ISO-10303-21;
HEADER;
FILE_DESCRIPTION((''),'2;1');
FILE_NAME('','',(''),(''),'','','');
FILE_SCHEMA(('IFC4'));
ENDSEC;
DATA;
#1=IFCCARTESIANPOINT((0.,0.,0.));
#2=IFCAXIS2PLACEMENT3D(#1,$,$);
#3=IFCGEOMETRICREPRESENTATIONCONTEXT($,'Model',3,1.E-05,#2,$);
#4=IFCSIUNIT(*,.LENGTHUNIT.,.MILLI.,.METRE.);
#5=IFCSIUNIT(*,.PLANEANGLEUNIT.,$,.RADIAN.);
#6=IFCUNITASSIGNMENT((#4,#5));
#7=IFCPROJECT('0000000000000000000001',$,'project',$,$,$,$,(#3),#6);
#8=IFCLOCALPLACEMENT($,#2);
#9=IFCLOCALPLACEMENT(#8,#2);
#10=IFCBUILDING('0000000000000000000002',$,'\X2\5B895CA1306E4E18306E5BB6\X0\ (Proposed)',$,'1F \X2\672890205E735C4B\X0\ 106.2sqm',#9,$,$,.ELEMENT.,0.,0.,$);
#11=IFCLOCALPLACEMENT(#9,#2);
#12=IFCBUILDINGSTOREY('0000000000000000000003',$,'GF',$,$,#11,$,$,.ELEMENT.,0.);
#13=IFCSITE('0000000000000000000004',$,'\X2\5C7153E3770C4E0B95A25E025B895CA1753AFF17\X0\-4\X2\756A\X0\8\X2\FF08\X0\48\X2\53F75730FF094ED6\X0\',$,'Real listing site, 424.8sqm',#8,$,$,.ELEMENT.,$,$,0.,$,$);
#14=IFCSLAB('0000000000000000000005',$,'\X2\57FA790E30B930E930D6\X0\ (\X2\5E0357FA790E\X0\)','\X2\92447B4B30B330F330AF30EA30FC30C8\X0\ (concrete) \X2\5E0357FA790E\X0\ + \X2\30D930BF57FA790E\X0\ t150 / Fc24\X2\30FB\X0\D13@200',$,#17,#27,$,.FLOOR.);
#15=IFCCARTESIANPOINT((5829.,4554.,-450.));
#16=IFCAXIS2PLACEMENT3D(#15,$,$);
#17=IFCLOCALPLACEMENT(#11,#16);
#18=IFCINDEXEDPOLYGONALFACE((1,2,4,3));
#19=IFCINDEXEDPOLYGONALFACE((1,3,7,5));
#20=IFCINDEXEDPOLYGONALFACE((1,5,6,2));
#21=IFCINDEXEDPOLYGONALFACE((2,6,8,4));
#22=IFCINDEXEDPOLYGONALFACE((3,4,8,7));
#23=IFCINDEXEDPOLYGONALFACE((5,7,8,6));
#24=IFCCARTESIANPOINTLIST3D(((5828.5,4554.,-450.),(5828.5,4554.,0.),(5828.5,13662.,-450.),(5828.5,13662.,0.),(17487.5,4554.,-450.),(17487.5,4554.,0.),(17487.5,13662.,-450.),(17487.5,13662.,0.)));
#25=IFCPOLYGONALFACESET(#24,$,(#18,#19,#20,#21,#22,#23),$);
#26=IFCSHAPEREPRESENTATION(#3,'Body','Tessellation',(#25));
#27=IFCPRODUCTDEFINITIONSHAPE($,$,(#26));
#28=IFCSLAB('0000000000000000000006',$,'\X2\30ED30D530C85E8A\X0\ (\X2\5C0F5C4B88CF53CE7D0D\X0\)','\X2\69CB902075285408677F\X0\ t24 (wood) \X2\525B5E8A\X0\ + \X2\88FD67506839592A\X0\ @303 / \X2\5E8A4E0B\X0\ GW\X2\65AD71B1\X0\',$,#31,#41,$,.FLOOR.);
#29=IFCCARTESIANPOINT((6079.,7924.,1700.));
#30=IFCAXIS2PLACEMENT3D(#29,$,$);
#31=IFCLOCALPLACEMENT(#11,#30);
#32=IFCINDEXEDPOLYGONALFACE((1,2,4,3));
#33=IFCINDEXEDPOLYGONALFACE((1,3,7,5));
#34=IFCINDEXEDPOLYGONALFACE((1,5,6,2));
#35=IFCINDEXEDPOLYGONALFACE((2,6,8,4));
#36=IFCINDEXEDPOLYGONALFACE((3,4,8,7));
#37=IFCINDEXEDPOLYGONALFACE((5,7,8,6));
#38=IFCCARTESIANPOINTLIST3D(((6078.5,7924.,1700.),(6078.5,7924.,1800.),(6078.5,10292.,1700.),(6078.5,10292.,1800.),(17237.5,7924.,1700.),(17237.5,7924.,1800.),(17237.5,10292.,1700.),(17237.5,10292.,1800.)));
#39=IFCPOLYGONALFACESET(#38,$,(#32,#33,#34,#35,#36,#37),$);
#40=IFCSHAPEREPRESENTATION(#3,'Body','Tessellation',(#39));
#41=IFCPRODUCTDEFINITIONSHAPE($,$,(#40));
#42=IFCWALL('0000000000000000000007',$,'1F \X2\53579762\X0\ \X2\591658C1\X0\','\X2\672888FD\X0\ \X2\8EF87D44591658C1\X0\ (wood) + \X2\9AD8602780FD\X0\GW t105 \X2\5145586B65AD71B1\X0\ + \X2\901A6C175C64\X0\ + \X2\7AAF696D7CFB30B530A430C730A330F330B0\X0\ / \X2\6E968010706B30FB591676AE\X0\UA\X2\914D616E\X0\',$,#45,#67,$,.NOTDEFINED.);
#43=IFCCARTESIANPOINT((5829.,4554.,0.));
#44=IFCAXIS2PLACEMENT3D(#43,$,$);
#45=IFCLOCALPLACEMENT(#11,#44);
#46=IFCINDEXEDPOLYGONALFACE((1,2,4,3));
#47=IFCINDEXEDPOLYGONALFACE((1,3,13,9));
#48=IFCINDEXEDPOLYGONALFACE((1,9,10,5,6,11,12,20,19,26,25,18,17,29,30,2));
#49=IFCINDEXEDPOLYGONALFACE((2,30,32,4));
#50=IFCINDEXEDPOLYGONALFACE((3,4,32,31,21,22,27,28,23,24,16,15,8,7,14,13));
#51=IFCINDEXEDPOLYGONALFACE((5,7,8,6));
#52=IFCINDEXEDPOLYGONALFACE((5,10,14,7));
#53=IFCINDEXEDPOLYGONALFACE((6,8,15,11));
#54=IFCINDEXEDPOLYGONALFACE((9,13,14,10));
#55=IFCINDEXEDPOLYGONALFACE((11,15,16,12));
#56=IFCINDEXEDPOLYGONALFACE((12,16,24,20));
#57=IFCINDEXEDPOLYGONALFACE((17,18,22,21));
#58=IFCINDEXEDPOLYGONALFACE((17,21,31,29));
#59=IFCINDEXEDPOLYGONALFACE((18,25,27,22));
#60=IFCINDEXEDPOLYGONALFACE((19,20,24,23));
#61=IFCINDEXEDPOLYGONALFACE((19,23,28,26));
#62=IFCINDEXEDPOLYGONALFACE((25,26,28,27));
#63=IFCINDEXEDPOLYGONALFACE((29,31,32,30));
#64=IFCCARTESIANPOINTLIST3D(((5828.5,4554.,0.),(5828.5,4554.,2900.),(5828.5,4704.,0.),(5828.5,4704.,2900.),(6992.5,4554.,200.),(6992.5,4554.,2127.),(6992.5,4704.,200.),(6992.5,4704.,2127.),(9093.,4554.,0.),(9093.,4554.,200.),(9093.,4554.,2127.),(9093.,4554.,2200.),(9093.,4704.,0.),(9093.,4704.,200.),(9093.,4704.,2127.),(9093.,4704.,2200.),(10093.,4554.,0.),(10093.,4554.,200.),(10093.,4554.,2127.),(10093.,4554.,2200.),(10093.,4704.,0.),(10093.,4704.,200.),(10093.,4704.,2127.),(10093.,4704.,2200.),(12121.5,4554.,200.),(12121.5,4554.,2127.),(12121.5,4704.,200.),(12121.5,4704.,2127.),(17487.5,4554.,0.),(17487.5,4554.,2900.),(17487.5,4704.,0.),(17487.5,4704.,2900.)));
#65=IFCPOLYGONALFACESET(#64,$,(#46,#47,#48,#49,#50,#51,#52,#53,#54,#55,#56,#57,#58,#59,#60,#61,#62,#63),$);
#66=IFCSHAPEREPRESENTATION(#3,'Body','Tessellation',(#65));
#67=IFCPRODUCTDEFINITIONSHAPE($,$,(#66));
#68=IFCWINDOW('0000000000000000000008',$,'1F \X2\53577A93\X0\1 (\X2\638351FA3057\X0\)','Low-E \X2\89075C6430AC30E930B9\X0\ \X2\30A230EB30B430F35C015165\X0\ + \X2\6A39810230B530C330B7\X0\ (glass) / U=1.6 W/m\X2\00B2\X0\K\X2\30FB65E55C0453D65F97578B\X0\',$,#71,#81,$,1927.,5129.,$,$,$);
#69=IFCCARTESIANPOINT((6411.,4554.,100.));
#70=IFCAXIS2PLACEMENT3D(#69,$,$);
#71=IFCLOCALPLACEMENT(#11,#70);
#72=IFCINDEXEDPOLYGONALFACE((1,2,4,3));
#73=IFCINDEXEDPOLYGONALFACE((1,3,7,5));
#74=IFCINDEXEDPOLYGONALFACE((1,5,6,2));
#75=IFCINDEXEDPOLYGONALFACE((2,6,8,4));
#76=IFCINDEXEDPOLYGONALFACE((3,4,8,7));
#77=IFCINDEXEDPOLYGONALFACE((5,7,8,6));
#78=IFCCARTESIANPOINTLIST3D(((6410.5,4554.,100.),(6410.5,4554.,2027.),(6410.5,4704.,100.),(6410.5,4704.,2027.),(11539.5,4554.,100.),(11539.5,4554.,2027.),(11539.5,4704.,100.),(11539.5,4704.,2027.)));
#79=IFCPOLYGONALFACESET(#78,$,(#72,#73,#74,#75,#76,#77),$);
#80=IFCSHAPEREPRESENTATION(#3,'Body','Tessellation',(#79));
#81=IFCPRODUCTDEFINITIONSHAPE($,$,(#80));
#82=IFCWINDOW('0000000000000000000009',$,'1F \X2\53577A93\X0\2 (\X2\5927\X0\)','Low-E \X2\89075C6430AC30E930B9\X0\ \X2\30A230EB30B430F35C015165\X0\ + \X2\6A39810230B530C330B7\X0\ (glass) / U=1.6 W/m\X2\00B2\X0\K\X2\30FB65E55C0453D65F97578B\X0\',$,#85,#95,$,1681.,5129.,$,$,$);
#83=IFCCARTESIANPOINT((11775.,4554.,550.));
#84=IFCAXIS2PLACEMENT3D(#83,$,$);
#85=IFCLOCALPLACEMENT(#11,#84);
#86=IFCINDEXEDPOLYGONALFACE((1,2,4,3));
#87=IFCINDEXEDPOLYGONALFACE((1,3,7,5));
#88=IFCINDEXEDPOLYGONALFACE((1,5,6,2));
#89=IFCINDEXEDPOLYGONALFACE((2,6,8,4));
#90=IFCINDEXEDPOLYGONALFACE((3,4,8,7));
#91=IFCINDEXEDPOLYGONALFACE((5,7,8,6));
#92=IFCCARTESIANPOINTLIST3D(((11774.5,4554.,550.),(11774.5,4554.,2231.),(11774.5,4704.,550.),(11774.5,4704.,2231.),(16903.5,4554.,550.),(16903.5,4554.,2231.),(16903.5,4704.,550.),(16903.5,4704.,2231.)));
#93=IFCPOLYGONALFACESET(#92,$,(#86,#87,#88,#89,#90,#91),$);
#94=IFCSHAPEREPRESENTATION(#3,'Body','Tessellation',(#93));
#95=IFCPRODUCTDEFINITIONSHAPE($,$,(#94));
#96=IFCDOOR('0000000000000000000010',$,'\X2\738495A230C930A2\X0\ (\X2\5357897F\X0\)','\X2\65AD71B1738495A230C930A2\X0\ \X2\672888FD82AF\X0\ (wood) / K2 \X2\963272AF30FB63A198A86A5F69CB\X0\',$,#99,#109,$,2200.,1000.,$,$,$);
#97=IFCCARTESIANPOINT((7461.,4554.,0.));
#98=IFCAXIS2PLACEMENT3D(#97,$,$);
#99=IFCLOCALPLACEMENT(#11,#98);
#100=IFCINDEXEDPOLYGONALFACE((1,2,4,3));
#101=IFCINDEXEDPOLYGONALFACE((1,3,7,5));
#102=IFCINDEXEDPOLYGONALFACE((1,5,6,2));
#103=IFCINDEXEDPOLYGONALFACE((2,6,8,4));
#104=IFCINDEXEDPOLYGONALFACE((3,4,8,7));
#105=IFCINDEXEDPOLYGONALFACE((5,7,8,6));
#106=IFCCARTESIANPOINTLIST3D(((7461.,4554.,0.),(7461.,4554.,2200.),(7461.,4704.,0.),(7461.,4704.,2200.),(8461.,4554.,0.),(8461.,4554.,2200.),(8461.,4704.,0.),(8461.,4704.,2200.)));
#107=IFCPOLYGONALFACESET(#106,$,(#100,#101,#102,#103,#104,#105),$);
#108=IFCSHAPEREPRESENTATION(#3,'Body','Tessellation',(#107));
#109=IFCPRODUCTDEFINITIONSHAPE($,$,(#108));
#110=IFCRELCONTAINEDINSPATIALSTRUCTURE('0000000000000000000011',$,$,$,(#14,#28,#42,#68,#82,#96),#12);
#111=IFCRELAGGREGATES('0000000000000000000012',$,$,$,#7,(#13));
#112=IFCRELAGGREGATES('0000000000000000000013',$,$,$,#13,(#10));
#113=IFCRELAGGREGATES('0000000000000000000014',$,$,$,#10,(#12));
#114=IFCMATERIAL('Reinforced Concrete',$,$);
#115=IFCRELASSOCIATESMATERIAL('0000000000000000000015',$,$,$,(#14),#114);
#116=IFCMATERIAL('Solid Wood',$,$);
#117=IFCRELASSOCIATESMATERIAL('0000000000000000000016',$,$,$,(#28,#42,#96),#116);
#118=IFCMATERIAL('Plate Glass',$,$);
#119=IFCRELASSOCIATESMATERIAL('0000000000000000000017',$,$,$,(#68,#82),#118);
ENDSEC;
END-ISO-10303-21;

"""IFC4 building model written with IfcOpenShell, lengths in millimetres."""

from ifc_helpers import new_model, si_unit, frame, frame_2d, origin, place, context, project, spatial, rectangle, extrude, material, element, fill, save


model = new_model("IFC4")

# Units and contexts
model_context = context("Model", 3, precision=1e-05, world=origin())
ifc_project = project(units=[si_unit("LENGTHUNIT", "METRE", prefix="MILLI"), si_unit("PLANEANGLEUNIT", "RADIAN")], contexts=[model_context])

# Site, building, storey
site_placement = place(None, origin())
site = spatial("IfcSite", under=ifc_project, at=site_placement, Name="山口県下関市安岡町７-4番8（48号地）他", ObjectType="Real listing site, 424.8sqm", CompositionType="ELEMENT", RefElevation=0.0)
building_placement = place(site_placement, origin())
building = spatial("IfcBuilding", under=site, at=building_placement, Name="安岡の丘の家 (Proposed)", ObjectType="1F 木造平屋 106.2sqm", CompositionType="ELEMENT", ElevationOfRefHeight=0.0, ElevationOfTerrain=0.0)
storey_placement = place(building_placement, origin())
storey = spatial("IfcBuildingStorey", under=building, at=storey_placement, Name="GF", CompositionType="ELEMENT", Elevation=0.0)

# Slabs
ifc_material_1 = material(Name="Reinforced Concrete")
slab_1_placement = place(storey_placement, frame((5829.0, 4554.0, -450.0)))
element("IfcSlab", 1, at=slab_1_placement, inside=storey, material=ifc_material_1, Name="基礎スラブ (布基礎)", Description="鉄筋コンクリート (concrete) 布基礎 + ベタ基礎 t150 / Fc24・D13@200", PredefinedType="FLOOR", context=model_context, shape_type="SweptSolid", body=[
    extrude(rectangle(XDim=11659.0, YDim=9108.0, at=frame_2d((5829.0, 4554.0))), frame((5829.0, 4554.0, -450.0)), (0.0, 0.0, 1.0), 450.0),
])
ifc_material_2 = material(Name="Solid Wood")
slab_2_placement = place(storey_placement, frame((6079.0, 7924.0, 1700.0)))
element("IfcSlab", 2, at=slab_2_placement, inside=storey, material=ifc_material_2, Name="ロフト床 (小屋裏収納)", Description="構造用合板 t24 (wood) 剛床 + 製材根太 @303 / 床下 GW断熱", PredefinedType="FLOOR", context=model_context, shape_type="SweptSolid", body=[
    extrude(rectangle(XDim=11159.0, YDim=2368.0, at=frame_2d((5579.0, 1184.0))), frame((6079.0, 7924.0, 1700.0)), (0.0, 0.0, 1.0), 100.0),
])

# Wall, openings, windows, door
wall_1_placement = place(storey_placement, frame((5829.0, 4554.0, 0.0)))
wall_1 = element("IfcWall", 3, at=wall_1_placement, inside=storey, material=ifc_material_2, Name="1F 南面 外壁", Description="木製 軸組外壁 (wood) + 高性能GW t105 充填断熱 + 通気層 + 窯業系サイディング / 準耐火・外皮UA配慮", PredefinedType="NOTDEFINED", context=model_context, shape_type="SweptSolid", body=[
    extrude(rectangle(XDim=11659.0, YDim=150.0, at=frame_2d((5829.0, 75.0))), frame((5829.0, 4554.0, 0.0)), (0.0, 0.0, 1.0), 2900.0),
])
opening_1_placement = place(storey_placement, frame((6411.0, 4554.0, 100.0)))
opening_1 = element("IfcOpeningElement", 4, at=opening_1_placement, cuts=wall_1, PredefinedType="NOTDEFINED", context=model_context, shape_type="SweptSolid", body=[
    extrude(rectangle(XDim=5129.0, YDim=150.0, at=frame_2d((2564.0, 75.0))), frame((6411.0, 4554.0, 100.0)), (0.0, 0.0, 1.0), 1927.0),
])
opening_2_placement = place(storey_placement, frame((11775.0, 4554.0, 550.0)))
opening_2 = element("IfcOpeningElement", 5, at=opening_2_placement, cuts=wall_1, PredefinedType="NOTDEFINED", context=model_context, shape_type="SweptSolid", body=[
    extrude(rectangle(XDim=5129.0, YDim=150.0, at=frame_2d((2564.0, 75.0))), frame((11775.0, 4554.0, 550.0)), (0.0, 0.0, 1.0), 1681.0),
])
opening_3_placement = place(storey_placement, frame((7461.0, 4554.0, 0.0)))
opening_3 = element("IfcOpeningElement", 6, at=opening_3_placement, cuts=wall_1, PredefinedType="NOTDEFINED", context=model_context, shape_type="SweptSolid", body=[
    extrude(rectangle(XDim=1000.0, YDim=150.0, at=frame_2d((500.0, 75.0))), frame((7461.0, 4554.0, 0.0)), (0.0, 0.0, 1.0), 2200.0),
])
ifc_material_3 = material(Name="Plate Glass")
window_1_placement = place(storey_placement, frame((6411.0, 4554.0, 100.0)))
window_1 = element("IfcWindow", 7, at=window_1_placement, inside=storey, material=ifc_material_3, Name="1F 南窓1 (掃出し)", Description="Low-E 複層ガラス アルゴン封入 + 樹脂サッシ (glass) / U=1.6 W/m²K・日射取得型", OverallHeight=1927.0, OverallWidth=5129.0, context=model_context, shape_type="SweptSolid", body=[
    extrude(rectangle(XDim=5129.0, YDim=150.0, at=frame_2d((2564.0, 75.0))), frame((6411.0, 4554.0, 100.0)), (0.0, 0.0, 1.0), 1927.0),
])
fill(opening_1, window_1)
window_2_placement = place(storey_placement, frame((11775.0, 4554.0, 550.0)))
window_2 = element("IfcWindow", 8, at=window_2_placement, inside=storey, material=ifc_material_3, Name="1F 南窓2 (大)", Description="Low-E 複層ガラス アルゴン封入 + 樹脂サッシ (glass) / U=1.6 W/m²K・日射取得型", OverallHeight=1681.0, OverallWidth=5129.0, context=model_context, shape_type="SweptSolid", body=[
    extrude(rectangle(XDim=5129.0, YDim=150.0, at=frame_2d((2564.0, 75.0))), frame((11775.0, 4554.0, 550.0)), (0.0, 0.0, 1.0), 1681.0),
])
fill(opening_2, window_2)
door_1_placement = place(storey_placement, frame((7461.0, 4554.0, 0.0)))
door_1 = element("IfcDoor", 9, at=door_1_placement, inside=storey, material=ifc_material_2, Name="玄関ドア (南西)", Description="断熱玄関ドア 木製芯 (wood) / K2 防犯・採風機構", OverallHeight=2200.0, OverallWidth=1000.0, context=model_context, shape_type="SweptSolid", body=[
    extrude(rectangle(XDim=1000.0, YDim=150.0, at=frame_2d((500.0, 75.0))), frame((7461.0, 4554.0, 0.0)), (0.0, 0.0, 1.0), 2200.0),
])
fill(opening_3, door_1)

save(model, "model.ifc")
